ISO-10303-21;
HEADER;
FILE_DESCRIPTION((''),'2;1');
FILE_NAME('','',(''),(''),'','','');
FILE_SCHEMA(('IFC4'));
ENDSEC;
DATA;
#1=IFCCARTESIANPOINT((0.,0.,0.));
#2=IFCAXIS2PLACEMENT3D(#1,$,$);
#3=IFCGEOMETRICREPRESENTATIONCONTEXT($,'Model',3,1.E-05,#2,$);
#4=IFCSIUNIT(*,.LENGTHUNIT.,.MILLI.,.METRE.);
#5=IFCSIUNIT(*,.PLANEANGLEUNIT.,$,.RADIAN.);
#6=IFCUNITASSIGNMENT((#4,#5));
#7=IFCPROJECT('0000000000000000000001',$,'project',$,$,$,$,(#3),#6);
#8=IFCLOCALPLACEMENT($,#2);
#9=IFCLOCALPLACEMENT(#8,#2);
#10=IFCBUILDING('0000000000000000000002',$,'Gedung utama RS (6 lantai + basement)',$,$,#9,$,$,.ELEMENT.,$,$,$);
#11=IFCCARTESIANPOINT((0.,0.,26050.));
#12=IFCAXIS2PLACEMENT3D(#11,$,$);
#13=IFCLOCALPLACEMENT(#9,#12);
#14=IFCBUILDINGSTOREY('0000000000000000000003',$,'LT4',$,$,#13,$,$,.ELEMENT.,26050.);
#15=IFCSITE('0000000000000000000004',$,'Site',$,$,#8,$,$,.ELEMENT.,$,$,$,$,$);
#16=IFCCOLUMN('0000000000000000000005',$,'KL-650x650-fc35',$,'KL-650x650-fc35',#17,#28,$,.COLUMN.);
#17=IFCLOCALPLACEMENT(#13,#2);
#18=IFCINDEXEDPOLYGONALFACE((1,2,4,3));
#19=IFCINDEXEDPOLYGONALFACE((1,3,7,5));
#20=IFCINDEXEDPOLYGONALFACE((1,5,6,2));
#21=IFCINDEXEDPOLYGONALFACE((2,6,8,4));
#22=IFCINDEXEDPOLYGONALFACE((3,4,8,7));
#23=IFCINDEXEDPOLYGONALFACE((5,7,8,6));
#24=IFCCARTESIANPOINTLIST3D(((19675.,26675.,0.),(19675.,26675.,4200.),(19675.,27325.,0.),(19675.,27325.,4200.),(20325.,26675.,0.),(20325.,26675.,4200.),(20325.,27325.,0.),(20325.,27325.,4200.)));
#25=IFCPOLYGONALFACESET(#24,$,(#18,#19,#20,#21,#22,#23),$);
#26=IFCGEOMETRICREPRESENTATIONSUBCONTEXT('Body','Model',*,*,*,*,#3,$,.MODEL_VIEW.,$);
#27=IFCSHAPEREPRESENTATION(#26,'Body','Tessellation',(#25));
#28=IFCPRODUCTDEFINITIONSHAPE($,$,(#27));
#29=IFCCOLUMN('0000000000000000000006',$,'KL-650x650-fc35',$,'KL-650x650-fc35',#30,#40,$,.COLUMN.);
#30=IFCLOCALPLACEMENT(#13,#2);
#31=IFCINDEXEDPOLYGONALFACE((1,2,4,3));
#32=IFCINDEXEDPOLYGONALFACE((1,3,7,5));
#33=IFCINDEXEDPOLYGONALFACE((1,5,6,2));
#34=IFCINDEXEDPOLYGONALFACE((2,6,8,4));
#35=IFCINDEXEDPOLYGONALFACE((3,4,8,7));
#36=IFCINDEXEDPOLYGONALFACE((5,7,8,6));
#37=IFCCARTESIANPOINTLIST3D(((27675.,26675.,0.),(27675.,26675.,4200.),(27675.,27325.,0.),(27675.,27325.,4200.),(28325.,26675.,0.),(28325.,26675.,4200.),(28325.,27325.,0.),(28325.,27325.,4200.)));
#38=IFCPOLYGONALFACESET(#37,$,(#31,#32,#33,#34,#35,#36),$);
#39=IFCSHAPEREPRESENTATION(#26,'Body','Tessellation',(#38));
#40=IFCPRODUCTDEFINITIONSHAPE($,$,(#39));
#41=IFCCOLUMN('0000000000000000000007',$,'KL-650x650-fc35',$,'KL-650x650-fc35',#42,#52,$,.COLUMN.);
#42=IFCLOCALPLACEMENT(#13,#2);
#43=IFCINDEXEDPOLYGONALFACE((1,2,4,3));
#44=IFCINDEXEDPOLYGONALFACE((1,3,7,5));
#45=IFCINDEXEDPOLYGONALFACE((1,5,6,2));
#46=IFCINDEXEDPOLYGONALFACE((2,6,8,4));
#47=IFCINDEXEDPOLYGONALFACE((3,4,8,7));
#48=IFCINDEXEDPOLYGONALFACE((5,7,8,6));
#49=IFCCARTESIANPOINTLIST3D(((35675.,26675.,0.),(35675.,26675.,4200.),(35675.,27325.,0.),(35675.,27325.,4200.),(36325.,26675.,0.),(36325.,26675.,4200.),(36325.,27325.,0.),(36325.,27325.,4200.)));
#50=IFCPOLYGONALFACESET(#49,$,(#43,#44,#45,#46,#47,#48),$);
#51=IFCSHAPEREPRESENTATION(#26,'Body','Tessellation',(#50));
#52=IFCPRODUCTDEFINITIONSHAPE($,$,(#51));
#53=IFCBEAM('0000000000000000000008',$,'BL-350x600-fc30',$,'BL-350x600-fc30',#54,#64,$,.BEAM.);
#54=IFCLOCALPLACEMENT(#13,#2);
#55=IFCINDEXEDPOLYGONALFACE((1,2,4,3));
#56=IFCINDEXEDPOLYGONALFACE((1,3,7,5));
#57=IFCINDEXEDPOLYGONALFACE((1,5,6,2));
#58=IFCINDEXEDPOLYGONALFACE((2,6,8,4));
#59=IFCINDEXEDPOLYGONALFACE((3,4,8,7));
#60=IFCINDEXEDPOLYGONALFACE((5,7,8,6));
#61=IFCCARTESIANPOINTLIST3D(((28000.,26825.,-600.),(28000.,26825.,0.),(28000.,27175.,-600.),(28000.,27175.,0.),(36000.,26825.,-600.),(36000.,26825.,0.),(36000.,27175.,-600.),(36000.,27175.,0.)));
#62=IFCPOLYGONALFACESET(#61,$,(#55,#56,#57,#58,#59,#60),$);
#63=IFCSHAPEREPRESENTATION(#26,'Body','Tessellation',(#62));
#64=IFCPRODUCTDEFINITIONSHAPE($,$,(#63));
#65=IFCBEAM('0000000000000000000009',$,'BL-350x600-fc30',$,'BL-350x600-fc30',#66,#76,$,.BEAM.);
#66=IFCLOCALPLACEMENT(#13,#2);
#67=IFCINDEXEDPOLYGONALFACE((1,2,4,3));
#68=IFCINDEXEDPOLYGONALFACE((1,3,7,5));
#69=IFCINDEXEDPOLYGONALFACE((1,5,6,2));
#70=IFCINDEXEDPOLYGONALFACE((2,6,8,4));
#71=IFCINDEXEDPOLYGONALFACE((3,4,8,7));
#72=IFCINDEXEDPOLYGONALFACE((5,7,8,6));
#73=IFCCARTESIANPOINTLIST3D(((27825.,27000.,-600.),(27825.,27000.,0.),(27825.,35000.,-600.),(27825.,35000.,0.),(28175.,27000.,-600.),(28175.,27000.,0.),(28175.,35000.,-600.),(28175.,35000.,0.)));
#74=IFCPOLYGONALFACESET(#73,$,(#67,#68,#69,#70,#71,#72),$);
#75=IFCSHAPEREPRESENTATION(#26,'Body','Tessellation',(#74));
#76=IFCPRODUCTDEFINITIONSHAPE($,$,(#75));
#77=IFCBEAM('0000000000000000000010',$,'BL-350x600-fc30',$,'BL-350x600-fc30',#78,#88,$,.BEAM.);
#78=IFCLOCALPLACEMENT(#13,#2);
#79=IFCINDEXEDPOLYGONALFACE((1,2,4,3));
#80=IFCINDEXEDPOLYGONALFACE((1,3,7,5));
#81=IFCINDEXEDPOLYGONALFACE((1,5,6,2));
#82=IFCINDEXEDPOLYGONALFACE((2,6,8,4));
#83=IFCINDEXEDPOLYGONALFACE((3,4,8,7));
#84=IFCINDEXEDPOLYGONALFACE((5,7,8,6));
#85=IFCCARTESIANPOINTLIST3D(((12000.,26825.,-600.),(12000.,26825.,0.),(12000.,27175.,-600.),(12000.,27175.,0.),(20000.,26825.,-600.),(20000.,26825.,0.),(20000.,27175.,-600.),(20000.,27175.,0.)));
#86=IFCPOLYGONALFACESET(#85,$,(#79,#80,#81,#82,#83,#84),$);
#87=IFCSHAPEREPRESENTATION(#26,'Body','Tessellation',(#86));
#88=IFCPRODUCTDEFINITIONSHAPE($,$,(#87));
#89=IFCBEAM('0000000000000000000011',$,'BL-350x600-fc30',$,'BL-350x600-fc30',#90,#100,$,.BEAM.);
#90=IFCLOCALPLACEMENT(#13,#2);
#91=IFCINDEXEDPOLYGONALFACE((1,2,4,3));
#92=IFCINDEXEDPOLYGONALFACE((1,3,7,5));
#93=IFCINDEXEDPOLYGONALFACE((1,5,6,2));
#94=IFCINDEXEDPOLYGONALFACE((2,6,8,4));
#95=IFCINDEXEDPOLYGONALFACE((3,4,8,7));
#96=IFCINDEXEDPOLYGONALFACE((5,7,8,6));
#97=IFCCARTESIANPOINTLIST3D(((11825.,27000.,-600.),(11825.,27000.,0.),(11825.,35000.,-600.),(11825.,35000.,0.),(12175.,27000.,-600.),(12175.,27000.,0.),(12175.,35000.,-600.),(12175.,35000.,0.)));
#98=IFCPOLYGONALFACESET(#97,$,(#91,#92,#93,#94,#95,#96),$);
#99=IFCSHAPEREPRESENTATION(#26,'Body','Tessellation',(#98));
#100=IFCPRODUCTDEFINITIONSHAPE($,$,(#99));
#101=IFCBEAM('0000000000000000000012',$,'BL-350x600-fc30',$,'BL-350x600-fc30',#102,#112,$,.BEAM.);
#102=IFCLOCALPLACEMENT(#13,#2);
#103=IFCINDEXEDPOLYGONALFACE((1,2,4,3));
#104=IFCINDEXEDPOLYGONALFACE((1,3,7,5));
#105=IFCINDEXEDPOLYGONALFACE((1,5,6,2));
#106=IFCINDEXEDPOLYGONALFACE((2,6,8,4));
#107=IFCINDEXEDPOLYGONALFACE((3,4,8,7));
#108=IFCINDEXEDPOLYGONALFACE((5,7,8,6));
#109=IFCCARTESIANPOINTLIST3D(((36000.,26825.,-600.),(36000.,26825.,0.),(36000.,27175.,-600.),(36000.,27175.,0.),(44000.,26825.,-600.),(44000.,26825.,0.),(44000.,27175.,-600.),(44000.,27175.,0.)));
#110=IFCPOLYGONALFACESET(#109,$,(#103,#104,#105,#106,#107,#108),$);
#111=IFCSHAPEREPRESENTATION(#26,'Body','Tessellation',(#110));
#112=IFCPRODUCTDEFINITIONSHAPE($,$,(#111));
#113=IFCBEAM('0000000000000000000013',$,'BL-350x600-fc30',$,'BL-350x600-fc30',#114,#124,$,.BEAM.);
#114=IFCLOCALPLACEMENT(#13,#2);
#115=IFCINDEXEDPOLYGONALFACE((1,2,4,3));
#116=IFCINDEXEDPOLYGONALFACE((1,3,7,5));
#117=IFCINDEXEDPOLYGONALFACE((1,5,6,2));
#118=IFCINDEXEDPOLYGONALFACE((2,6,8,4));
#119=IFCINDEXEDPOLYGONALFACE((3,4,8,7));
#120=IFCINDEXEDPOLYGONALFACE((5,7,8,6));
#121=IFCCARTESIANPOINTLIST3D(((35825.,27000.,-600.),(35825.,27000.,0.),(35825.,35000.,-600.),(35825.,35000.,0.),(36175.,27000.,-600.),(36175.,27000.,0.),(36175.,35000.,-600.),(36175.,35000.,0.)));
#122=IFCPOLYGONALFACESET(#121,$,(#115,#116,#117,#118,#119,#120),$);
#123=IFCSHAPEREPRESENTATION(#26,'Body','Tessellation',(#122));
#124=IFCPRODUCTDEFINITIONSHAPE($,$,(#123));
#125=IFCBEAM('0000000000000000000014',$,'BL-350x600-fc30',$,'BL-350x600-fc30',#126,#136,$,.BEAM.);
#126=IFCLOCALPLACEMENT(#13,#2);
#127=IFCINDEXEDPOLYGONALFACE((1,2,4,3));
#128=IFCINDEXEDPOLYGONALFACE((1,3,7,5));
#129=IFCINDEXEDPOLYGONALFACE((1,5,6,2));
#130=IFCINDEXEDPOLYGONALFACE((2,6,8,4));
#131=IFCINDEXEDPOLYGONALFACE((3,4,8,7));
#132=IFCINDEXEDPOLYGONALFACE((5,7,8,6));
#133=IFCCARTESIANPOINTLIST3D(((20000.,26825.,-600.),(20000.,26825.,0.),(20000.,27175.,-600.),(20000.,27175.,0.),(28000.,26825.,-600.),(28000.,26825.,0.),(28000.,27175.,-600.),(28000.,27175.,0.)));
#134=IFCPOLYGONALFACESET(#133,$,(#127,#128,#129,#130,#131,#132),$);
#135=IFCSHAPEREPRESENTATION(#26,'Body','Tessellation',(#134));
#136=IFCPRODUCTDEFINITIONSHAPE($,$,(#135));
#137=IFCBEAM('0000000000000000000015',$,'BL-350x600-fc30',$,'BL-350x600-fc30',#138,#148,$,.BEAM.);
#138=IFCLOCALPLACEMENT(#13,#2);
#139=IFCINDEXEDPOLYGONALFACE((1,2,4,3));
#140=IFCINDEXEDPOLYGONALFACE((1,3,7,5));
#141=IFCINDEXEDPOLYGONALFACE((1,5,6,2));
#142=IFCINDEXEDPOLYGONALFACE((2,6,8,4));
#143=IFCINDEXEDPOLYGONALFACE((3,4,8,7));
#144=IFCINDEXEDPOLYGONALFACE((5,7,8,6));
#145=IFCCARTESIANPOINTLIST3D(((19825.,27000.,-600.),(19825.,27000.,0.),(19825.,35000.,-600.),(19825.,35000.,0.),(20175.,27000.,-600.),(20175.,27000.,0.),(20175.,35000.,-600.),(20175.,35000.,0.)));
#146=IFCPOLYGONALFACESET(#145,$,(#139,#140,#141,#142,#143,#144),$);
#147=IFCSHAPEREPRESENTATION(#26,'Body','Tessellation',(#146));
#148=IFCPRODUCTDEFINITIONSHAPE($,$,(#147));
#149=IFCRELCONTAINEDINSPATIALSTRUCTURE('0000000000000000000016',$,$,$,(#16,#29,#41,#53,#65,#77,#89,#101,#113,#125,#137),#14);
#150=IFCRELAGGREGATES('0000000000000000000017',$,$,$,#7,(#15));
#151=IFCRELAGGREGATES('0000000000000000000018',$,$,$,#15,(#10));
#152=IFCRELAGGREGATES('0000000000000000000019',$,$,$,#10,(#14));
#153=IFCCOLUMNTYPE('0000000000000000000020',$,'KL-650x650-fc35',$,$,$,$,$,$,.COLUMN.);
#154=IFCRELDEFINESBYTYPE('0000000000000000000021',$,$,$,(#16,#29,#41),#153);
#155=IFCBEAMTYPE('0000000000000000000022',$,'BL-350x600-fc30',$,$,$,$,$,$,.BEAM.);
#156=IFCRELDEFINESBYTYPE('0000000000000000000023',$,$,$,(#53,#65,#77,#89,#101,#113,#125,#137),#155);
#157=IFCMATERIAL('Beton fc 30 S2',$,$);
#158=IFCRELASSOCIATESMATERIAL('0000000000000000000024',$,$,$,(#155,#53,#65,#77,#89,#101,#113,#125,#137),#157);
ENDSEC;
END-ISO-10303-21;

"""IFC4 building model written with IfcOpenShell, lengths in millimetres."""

from ifc_helpers import new_model, si_unit, frame, origin, origin_2d, place, context, subcontext, project, spatial, rectangle, extrude, material, material_profile, profile_set, profile_usage, type_object, element, save


model = new_model("IFC4")

# Units and contexts
model_context = context("Model", 3, precision=1e-05, world=origin())
body_context = subcontext(model_context, "Body", "Model", "MODEL_VIEW")
ifc_project = project(units=[si_unit("LENGTHUNIT", "METRE", prefix="MILLI"), si_unit("PLANEANGLEUNIT", "RADIAN")], contexts=[model_context])

# Site, building, storey
site_placement = place(None, origin())
site = spatial("IfcSite", under=ifc_project, at=site_placement, Name="Site", CompositionType="ELEMENT")
building_placement = place(site_placement, origin())
building = spatial("IfcBuilding", under=site, at=building_placement, Name="Gedung utama RS (6 lantai + basement)", CompositionType="ELEMENT")
storey_placement = place(building_placement, frame((0.0, 0.0, 26050.0)))
storey = spatial("IfcBuildingStorey", under=building, at=storey_placement, Name="LT4", CompositionType="ELEMENT", Elevation=26050.0)

# Columns
ifc_material_profile_1 = material_profile(None, rectangle(XDim=650.0, YDim=650.0, at=origin_2d()), Name="KL-650x650-fc35")
ifc_profile_set_1 = profile_set([ifc_material_profile_1], Name="KL-650x650-fc35")
ifc_profile_usage_1 = profile_usage(ifc_profile_set_1, cardinal=5)
column_type = type_object("IfcColumnType", Name="KL-650x650-fc35", PredefinedType="COLUMN", material=ifc_profile_set_1)
for number, where, z_axis, x_axis, name in (
    (1, (20000.0, 27000.0, 0.0), (0.0, 0.0, 1.0), (1.0, 0.0, 0.0), "KL-650x650-fc35"),
    (2, (28000.0, 27000.0, 0.0), (0.0, 0.0, 1.0), (1.0, 0.0, 0.0), "KL-650x650-fc35"),
    (3, (36000.0, 27000.0, 0.0), (0.0, 0.0, 1.0), (1.0, 0.0, 0.0), "KL-650x650-fc35"),
):
    element("IfcColumn", number, at=place(storey_placement, frame(where, z_axis=z_axis, x_axis=x_axis)), inside=storey, type_object=column_type, material=ifc_profile_usage_1, Name=name, ObjectType="KL-650x650-fc35", PredefinedType="COLUMN", context=body_context, shape_type="SweptSolid", body=[
        extrude(rectangle(XDim=650.0, YDim=650.0, at=origin_2d()), origin(), (0.0, 0.0, 1.0), 4200.0),
    ])

# Beams
ifc_material = material(Name="Beton fc 30 S2")
ifc_material_profile_2 = material_profile(ifc_material, rectangle(XDim=350.0, YDim=600.0, at=origin_2d()), Name="BL-350x600-fc30")
ifc_profile_set_2 = profile_set([ifc_material_profile_2], Name="BL-350x600-fc30")
ifc_profile_usage_2 = profile_usage(ifc_profile_set_2, cardinal=8)
beam_type = type_object("IfcBeamType", Name="BL-350x600-fc30", PredefinedType="BEAM", material=ifc_profile_set_2)
beam_1_placement = place(storey_placement, frame((28000.0, 27000.0, -300.0)))
element("IfcBeam", 4, at=beam_1_placement, inside=storey, type_object=beam_type, material=ifc_profile_usage_2, Name="BL-350x600-fc30", ObjectType="BL-350x600-fc30", PredefinedType="BEAM", context=body_context, shape_type="SweptSolid", body=[
    extrude(rectangle(XDim=350.0, YDim=600.0, at=origin_2d()), frame((0.0, 0.0, 0.0), z_axis=(1.0, 0.0, 0.0), x_axis=(0.0, 1.0, 0.0)), (0.0, 0.0, 1.0), 8000.0),
])
beam_2_placement = place(storey_placement, frame((28000.0, 27000.0, -300.0)))
element("IfcBeam", 5, at=beam_2_placement, inside=storey, type_object=beam_type, material=ifc_profile_usage_2, Name="BL-350x600-fc30", ObjectType="BL-350x600-fc30", PredefinedType="BEAM", context=body_context, shape_type="SweptSolid", body=[
    extrude(rectangle(XDim=350.0, YDim=600.0, at=origin_2d()), frame((0.0, 0.0, 0.0), z_axis=(0.0, 1.0, 0.0), x_axis=(-1.0, 0.0, 0.0)), (0.0, 0.0, 1.0), 8000.0),
])
beam_3_placement = place(storey_placement, frame((12000.0, 27000.0, -300.0)))
element("IfcBeam", 6, at=beam_3_placement, inside=storey, type_object=beam_type, material=ifc_profile_usage_2, Name="BL-350x600-fc30", ObjectType="BL-350x600-fc30", PredefinedType="BEAM", context=body_context, shape_type="SweptSolid", body=[
    extrude(rectangle(XDim=350.0, YDim=600.0, at=origin_2d()), frame((0.0, 0.0, 0.0), z_axis=(1.0, 0.0, 0.0), x_axis=(0.0, 1.0, 0.0)), (0.0, 0.0, 1.0), 8000.0),
])
beam_4_placement = place(storey_placement, frame((12000.0, 27000.0, -300.0)))
element("IfcBeam", 7, at=beam_4_placement, inside=storey, type_object=beam_type, material=ifc_profile_usage_2, Name="BL-350x600-fc30", ObjectType="BL-350x600-fc30", PredefinedType="BEAM", context=body_context, shape_type="SweptSolid", body=[
    extrude(rectangle(XDim=350.0, YDim=600.0, at=origin_2d()), frame((0.0, 0.0, 0.0), z_axis=(0.0, 1.0, 0.0), x_axis=(-1.0, 0.0, 0.0)), (0.0, 0.0, 1.0), 8000.0),
])
beam_5_placement = place(storey_placement, frame((36000.0, 27000.0, -300.0)))
element("IfcBeam", 8, at=beam_5_placement, inside=storey, type_object=beam_type, material=ifc_profile_usage_2, Name="BL-350x600-fc30", ObjectType="BL-350x600-fc30", PredefinedType="BEAM", context=body_context, shape_type="SweptSolid", body=[
    extrude(rectangle(XDim=350.0, YDim=600.0, at=origin_2d()), frame((0.0, 0.0, 0.0), z_axis=(1.0, 0.0, 0.0), x_axis=(0.0, 1.0, 0.0)), (0.0, 0.0, 1.0), 8000.0),
])
beam_6_placement = place(storey_placement, frame((36000.0, 27000.0, -300.0)))
element("IfcBeam", 9, at=beam_6_placement, inside=storey, type_object=beam_type, material=ifc_profile_usage_2, Name="BL-350x600-fc30", ObjectType="BL-350x600-fc30", PredefinedType="BEAM", context=body_context, shape_type="SweptSolid", body=[
    extrude(rectangle(XDim=350.0, YDim=600.0, at=origin_2d()), frame((0.0, 0.0, 0.0), z_axis=(0.0, 1.0, 0.0), x_axis=(-1.0, 0.0, 0.0)), (0.0, 0.0, 1.0), 8000.0),
])
beam_7_placement = place(storey_placement, frame((20000.0, 27000.0, -300.0)))
element("IfcBeam", 10, at=beam_7_placement, inside=storey, type_object=beam_type, material=ifc_profile_usage_2, Name="BL-350x600-fc30", ObjectType="BL-350x600-fc30", PredefinedType="BEAM", context=body_context, shape_type="SweptSolid", body=[
    extrude(rectangle(XDim=350.0, YDim=600.0, at=origin_2d()), frame((0.0, 0.0, 0.0), z_axis=(1.0, 0.0, 0.0), x_axis=(0.0, 1.0, 0.0)), (0.0, 0.0, 1.0), 8000.0),
])
beam_8_placement = place(storey_placement, frame((20000.0, 27000.0, -300.0)))
element("IfcBeam", 11, at=beam_8_placement, inside=storey, type_object=beam_type, material=ifc_profile_usage_2, Name="BL-350x600-fc30", ObjectType="BL-350x600-fc30", PredefinedType="BEAM", context=body_context, shape_type="SweptSolid", body=[
    extrude(rectangle(XDim=350.0, YDim=600.0, at=origin_2d()), frame((0.0, 0.0, 0.0), z_axis=(0.0, 1.0, 0.0), x_axis=(-1.0, 0.0, 0.0)), (0.0, 0.0, 1.0), 8000.0),
])

save(model, "model.ifc")
